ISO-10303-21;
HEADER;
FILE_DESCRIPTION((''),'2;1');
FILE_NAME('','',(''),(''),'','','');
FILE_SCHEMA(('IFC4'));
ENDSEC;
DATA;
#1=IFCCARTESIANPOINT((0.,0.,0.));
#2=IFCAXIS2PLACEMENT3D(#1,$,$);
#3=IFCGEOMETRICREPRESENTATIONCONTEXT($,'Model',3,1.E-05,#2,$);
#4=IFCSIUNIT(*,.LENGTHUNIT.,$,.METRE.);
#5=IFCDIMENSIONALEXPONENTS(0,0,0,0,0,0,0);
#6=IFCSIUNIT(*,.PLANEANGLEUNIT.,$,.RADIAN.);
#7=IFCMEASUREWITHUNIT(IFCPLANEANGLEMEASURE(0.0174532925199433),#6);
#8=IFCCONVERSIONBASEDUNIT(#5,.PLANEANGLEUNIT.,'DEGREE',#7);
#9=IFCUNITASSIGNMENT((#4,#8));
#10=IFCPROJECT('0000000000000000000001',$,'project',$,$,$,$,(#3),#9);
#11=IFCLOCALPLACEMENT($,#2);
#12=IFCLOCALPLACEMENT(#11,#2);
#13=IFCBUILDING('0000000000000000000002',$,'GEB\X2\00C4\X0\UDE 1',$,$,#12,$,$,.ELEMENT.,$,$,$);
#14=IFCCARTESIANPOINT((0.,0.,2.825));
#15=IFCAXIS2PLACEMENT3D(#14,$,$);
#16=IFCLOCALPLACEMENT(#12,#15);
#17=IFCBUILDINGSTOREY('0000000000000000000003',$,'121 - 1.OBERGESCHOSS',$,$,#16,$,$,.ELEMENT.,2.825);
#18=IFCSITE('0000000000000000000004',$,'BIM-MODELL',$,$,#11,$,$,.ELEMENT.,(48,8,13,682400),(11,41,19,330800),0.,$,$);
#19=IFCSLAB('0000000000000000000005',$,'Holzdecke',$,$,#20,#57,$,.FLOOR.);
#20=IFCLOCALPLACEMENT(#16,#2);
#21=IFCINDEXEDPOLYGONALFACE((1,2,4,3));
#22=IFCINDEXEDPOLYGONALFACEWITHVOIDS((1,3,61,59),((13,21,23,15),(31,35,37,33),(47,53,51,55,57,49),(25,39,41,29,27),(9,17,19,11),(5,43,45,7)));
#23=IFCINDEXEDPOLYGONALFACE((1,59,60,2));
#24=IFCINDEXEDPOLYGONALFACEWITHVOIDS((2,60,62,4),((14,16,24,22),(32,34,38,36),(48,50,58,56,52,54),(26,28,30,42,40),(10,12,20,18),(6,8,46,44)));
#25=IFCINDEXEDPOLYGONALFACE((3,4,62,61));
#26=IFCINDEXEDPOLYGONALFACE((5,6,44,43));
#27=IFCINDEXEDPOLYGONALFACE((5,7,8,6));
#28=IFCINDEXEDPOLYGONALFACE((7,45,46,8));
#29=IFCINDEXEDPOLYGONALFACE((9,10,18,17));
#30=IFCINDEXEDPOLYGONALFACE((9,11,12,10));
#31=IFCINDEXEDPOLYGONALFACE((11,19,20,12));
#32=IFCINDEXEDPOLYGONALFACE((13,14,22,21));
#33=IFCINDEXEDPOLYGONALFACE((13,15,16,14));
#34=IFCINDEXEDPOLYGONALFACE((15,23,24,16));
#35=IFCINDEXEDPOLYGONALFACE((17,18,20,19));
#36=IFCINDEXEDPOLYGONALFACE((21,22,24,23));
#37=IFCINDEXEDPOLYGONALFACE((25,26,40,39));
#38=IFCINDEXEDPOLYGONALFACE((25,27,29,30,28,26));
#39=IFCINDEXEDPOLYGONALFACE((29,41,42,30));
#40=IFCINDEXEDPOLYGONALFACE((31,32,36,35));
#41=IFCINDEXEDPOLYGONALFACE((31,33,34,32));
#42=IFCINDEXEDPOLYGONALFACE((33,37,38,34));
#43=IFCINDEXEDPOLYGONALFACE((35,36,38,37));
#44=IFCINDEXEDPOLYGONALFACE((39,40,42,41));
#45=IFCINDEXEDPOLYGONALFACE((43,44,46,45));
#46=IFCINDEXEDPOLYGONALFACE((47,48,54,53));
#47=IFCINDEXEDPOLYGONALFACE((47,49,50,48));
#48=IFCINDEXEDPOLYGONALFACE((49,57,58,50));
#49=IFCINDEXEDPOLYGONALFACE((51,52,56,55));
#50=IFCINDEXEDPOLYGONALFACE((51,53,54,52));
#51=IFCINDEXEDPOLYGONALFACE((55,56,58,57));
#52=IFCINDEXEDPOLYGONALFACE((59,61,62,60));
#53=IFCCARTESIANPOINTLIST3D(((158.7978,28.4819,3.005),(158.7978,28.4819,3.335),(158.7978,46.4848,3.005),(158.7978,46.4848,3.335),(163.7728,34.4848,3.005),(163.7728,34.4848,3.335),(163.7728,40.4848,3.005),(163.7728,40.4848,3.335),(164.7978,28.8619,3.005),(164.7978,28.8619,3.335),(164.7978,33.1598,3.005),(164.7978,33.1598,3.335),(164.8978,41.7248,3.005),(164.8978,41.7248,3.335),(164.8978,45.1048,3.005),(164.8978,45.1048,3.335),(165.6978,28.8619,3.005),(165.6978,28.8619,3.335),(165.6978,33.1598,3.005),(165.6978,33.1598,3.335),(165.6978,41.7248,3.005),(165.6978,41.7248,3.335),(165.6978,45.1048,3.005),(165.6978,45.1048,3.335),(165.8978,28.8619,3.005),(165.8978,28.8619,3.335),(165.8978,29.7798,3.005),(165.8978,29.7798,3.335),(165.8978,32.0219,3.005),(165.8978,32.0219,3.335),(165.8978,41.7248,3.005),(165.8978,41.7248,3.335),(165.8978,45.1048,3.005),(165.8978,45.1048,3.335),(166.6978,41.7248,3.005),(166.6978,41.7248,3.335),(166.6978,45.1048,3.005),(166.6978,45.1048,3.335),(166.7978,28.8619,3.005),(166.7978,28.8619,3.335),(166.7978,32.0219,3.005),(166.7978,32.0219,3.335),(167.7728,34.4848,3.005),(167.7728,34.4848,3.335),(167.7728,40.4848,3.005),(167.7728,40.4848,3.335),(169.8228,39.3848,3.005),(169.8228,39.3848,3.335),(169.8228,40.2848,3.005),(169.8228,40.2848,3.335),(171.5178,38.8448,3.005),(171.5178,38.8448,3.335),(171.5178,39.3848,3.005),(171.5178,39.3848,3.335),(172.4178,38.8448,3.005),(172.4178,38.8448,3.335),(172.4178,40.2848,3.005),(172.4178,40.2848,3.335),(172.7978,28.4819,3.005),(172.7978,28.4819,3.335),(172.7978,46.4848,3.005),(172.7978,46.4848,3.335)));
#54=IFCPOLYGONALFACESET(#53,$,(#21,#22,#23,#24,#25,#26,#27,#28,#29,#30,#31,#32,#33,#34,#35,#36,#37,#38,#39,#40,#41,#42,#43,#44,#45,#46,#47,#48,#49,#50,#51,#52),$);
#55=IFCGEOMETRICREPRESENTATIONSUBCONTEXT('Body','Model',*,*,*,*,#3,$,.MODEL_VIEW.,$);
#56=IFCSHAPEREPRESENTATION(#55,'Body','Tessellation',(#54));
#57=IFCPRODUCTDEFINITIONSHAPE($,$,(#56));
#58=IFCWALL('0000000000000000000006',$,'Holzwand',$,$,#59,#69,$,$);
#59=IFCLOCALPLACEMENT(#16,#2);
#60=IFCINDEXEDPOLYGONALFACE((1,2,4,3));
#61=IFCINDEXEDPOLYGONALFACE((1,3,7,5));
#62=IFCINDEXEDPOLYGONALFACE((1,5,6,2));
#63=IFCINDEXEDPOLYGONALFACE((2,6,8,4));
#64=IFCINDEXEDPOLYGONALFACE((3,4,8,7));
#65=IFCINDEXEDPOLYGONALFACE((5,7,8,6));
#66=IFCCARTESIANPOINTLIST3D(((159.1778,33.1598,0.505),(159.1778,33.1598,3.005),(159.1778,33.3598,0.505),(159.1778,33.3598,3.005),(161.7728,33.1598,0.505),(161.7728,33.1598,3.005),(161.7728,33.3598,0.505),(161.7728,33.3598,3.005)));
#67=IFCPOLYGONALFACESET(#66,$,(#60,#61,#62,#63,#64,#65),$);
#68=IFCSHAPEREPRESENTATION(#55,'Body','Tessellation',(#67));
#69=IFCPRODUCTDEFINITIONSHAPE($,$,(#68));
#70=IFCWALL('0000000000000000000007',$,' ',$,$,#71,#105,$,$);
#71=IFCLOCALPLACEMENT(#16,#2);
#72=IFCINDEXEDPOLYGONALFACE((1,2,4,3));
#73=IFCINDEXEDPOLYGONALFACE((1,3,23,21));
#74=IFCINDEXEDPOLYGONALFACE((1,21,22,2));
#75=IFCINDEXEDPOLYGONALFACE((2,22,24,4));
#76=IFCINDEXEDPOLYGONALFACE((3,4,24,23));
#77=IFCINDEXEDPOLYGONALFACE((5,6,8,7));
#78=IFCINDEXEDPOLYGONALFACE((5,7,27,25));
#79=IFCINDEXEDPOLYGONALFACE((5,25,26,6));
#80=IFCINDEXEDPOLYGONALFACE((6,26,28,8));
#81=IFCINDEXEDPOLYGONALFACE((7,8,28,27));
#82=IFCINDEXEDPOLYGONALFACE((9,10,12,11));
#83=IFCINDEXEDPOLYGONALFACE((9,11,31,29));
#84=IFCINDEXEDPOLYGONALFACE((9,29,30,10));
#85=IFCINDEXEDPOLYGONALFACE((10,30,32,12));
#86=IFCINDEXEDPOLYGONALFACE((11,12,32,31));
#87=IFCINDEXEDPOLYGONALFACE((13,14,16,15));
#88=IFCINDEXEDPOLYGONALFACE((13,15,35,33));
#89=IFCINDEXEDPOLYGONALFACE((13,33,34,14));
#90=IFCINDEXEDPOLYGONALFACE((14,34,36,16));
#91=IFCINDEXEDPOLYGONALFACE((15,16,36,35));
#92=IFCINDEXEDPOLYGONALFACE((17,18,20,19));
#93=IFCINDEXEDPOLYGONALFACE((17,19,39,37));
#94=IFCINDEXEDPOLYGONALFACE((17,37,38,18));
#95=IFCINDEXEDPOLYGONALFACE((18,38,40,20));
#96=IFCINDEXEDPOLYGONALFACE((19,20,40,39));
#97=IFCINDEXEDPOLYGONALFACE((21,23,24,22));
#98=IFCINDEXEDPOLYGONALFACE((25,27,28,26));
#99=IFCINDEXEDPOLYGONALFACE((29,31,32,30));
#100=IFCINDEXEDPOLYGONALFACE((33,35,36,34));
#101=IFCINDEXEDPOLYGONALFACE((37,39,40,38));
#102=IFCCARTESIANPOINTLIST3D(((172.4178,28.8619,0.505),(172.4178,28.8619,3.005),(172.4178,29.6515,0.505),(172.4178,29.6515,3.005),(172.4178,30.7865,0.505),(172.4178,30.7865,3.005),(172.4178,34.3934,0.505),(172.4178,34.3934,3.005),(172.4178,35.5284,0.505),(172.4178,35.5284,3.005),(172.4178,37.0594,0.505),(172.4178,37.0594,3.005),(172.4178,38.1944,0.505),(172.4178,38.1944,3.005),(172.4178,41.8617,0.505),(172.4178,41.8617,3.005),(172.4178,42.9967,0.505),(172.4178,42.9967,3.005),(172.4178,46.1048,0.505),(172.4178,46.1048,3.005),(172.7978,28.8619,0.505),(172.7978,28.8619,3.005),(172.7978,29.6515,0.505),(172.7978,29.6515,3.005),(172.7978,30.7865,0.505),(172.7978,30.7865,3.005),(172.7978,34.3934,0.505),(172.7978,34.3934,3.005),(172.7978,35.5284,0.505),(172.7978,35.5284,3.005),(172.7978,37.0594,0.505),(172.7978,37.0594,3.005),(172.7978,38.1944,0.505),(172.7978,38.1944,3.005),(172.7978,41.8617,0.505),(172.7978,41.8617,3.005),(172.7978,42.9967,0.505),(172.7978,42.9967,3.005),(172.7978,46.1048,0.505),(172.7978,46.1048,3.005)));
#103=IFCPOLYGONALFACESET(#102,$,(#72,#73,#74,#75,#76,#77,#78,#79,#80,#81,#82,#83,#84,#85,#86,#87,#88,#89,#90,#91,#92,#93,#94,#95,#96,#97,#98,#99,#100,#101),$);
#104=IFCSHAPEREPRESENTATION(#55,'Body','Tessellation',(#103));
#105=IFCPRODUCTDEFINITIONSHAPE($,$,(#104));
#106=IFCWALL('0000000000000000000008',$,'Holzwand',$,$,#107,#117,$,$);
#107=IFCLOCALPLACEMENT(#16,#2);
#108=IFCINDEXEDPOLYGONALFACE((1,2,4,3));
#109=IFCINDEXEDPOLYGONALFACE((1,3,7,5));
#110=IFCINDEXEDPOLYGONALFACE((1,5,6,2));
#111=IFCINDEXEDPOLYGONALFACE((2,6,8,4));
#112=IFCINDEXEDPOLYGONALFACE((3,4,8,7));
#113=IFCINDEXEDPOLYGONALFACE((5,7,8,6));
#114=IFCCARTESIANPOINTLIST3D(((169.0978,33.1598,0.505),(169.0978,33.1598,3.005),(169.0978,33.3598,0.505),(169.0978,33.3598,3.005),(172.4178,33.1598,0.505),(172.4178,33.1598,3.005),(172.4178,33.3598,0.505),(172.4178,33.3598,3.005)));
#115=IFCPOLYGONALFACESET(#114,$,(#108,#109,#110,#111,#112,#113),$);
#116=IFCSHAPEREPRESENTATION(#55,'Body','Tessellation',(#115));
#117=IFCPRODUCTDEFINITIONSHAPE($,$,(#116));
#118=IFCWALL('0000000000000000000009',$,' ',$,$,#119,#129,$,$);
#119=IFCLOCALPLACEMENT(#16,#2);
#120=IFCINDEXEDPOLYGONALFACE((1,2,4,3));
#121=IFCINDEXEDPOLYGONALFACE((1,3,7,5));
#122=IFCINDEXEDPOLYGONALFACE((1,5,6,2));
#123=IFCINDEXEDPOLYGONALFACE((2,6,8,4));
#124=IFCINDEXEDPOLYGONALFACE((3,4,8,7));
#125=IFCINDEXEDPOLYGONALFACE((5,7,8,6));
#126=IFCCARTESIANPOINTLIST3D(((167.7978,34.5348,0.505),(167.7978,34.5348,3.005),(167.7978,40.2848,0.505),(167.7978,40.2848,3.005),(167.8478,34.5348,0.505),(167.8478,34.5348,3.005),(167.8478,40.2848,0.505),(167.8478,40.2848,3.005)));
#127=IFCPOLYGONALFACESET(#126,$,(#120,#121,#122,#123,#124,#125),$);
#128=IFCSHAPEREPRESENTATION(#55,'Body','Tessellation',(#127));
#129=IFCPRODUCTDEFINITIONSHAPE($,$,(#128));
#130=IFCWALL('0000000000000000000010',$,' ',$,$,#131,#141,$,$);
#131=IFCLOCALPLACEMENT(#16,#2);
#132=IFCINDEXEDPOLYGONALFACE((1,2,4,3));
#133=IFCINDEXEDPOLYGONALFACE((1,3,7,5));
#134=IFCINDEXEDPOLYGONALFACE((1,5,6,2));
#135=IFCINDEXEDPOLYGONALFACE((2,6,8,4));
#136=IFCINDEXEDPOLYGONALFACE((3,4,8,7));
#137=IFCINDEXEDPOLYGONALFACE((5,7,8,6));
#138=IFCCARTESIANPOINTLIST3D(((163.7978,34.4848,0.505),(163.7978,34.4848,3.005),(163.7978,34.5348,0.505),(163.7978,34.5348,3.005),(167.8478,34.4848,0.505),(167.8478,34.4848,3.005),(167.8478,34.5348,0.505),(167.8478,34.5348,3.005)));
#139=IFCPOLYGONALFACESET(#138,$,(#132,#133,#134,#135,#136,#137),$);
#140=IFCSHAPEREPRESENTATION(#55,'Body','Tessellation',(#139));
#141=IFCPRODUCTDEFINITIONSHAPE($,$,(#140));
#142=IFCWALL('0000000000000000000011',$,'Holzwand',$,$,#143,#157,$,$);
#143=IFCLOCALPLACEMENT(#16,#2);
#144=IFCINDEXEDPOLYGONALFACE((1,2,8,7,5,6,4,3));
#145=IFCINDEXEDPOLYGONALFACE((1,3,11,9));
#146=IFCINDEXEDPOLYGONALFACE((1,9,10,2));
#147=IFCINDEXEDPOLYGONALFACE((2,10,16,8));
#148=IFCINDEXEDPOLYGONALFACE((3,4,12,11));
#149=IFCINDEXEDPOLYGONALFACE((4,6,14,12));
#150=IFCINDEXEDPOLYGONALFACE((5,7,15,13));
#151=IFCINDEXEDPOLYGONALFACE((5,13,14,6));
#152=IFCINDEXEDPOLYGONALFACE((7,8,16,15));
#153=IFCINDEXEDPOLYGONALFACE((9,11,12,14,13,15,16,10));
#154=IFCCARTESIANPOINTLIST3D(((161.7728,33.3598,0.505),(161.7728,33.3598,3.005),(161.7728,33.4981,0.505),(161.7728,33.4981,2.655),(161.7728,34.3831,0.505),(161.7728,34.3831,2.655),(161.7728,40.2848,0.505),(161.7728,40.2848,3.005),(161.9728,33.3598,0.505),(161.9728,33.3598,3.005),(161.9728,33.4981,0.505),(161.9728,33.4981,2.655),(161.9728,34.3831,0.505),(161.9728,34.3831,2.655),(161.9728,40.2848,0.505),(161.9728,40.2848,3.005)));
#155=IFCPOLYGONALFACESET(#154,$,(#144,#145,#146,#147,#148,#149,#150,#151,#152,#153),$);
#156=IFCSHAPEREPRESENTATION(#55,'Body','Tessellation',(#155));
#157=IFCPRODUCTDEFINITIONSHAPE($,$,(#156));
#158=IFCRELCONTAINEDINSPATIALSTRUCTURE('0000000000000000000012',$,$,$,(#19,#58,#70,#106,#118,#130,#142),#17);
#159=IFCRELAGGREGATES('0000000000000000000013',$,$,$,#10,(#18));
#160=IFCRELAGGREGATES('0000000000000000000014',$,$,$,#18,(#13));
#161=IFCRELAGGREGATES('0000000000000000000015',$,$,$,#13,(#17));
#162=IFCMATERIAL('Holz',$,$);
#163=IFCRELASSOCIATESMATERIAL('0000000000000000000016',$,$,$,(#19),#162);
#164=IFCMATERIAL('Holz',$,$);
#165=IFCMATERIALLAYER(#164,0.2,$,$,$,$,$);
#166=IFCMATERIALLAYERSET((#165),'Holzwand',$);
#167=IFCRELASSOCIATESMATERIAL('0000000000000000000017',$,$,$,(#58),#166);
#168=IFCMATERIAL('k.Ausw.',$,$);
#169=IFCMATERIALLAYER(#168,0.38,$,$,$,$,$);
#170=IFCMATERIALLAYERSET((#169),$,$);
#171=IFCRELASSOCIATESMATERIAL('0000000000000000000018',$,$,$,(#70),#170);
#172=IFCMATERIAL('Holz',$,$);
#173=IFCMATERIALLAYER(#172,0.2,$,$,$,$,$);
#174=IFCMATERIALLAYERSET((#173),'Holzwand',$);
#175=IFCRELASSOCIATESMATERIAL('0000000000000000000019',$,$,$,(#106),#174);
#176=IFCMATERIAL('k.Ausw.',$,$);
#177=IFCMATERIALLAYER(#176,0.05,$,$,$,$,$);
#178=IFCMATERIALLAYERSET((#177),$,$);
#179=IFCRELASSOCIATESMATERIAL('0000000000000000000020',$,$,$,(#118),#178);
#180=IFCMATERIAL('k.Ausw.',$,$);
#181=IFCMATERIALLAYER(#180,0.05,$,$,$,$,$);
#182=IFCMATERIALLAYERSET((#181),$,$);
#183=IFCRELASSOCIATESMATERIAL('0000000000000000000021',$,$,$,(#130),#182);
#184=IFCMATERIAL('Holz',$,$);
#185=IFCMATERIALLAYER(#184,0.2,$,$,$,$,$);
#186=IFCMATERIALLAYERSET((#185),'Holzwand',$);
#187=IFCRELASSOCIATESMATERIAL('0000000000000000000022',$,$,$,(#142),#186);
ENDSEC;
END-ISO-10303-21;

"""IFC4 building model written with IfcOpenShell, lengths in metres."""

from ifc_helpers import new_model, entity, si_unit, converted_unit, frame, frame_2d, origin, origin_with_axes, place, context, subcontext, project, spatial, polyline, rectangle, outline, extrude, material, layer, layer_set, layer_usage, element, save


model = new_model("IFC4")

# Units and contexts
model_context = context("Model", 3, precision=1e-05, world=origin())
body_context = subcontext(model_context, "Body", "Model", "MODEL_VIEW")
ifc_project = project(units=[si_unit("LENGTHUNIT", "METRE"), converted_unit("PLANEANGLEUNIT", "DEGREE", entity("IfcPlaneAngleMeasure", 0.0174532925199433), si_unit("PLANEANGLEUNIT", "RADIAN"), dimensions=[0, 0, 0, 0, 0, 0, 0])], contexts=[model_context])

# Site, building, storey
site_placement = place(None, origin())
site = spatial("IfcSite", under=ifc_project, at=site_placement, Name="BIM-MODELL", CompositionType="ELEMENT", RefLatitude=(48, 8, 13, 682400), RefLongitude=(11, 41, 19, 330800), RefElevation=0.0)
building_placement = place(site_placement, origin())
building = spatial("IfcBuilding", under=site, at=building_placement, Name="GEBÄUDE 1", CompositionType="ELEMENT")
storey_placement = place(building_placement, frame((0.0, 0.0, 2.825)))
storey = spatial("IfcBuildingStorey", under=building, at=storey_placement, Name="121 - 1.OBERGESCHOSS", CompositionType="ELEMENT", Elevation=2.825)

# Slab
ifc_material_1 = material(Name="Holz")
slab_placement = place(storey_placement, frame((158.7978, 28.4819, 3.005)))
element("IfcSlab", 1, at=slab_placement, inside=storey, material=ifc_material_1, Name="Holzdecke", PredefinedType="FLOOR", context=body_context, shape_type="SweptSolid", body=[
    extrude(outline(polyline([(0.0, 0.0), (14.0, 0.0), (14.0, 18.0029), (0.0, 18.0029), (0.0, 0.0)]), holes=[polyline([(4.975, 12.0029), (8.975, 12.0029), (8.975, 6.0029), (4.975, 6.0029), (4.975, 12.0029)]), polyline([(6.0, 4.6779), (6.9, 4.6779), (6.9, 0.38), (6.0, 0.38), (6.0, 4.6779)]), polyline([(7.1, 1.2979), (7.1, 3.54), (8.0, 3.54), (8.0, 0.38), (7.1, 0.38), (7.1, 1.2979)]), polyline([(13.62, 10.3629), (12.72, 10.3629), (12.72, 10.9029), (11.025, 10.9029), (11.025, 11.8029), (13.62, 11.8029), (13.62, 10.3629)]), polyline([(7.1, 13.2429), (7.1, 16.6229), (7.9, 16.6229), (7.9, 13.2429), (7.1, 13.2429)]), polyline([(6.9, 13.2429), (6.1, 13.2429), (6.1, 16.6229), (6.9, 16.6229), (6.9, 13.2429)])]), origin_with_axes(), (0.0, 0.0, 1.0), 0.33),
])

# Wall
ifc_material_2 = material(Name="Holz")
ifc_layer_1 = layer(ifc_material_2, 0.2)
ifc_layer_set_1 = layer_set([ifc_layer_1], Name="Holzwand")
ifc_layer_usage_1 = layer_usage(ifc_layer_set_1, "AXIS2", "POSITIVE", 0.0)
wall_1_placement = place(storey_placement, frame((159.1778, 33.1598, 0.505)))
element("IfcWall", 2, at=wall_1_placement, inside=storey, material=ifc_layer_usage_1, Name="Holzwand", context=body_context, shape_type="SweptSolid", body=[
    extrude(rectangle(XDim=2.595, YDim=0.2, at=frame_2d((1.2975, 0.1), x_axis=(1.0, 0.0))), origin_with_axes(), (0.0, 0.0, 1.0), 2.5),
])

# Wall, openings
ifc_material_3 = material(Name="k.Ausw.")
ifc_layer_2 = layer(ifc_material_3, 0.38)
ifc_layer_set_2 = layer_set([ifc_layer_2])
ifc_layer_usage_2 = layer_usage(ifc_layer_set_2, "AXIS2", "POSITIVE", 0.0)
wall_2_placement = place(storey_placement, frame((172.7978, 28.8619, 0.505), z_axis=(0.0, 0.0, 1.0), x_axis=(0.0, 1.0, 0.0)))
wall_2 = element("IfcWall", 3, at=wall_2_placement, inside=storey, material=ifc_layer_usage_2, Name=" ", context=body_context, shape_type="SweptSolid", body=[
    extrude(rectangle(XDim=17.2429, YDim=0.38, at=frame_2d((8.6214, 0.19), x_axis=(1.0, 0.0))), origin_with_axes(), (0.0, 0.0, 1.0), 2.5),
])
opening_1_placement = place(wall_2_placement, frame((14.1348, 0.38, 0.0), z_axis=(0.0, -1.0, 0.0), x_axis=(0.0, 0.0, 1.0)))
element("IfcOpeningElement", 4, at=opening_1_placement, cuts=wall_2, ObjectType="Opening", context=body_context, shape_type="SweptSolid", body=[
    extrude(outline(polyline([(0.0, 1.135), (2.5, 1.135), (2.5, 0.0), (0.0, 0.0), (0.0, 1.135)])), origin_with_axes(), (0.0, 0.0, 1.0), 0.38),
])
opening_2_placement = place(wall_2_placement, frame((9.3325, 0.38, 0.0), z_axis=(0.0, -1.0, 0.0), x_axis=(0.0, 0.0, 1.0)))
element("IfcOpeningElement", 5, at=opening_2_placement, cuts=wall_2, ObjectType="Opening", context=body_context, shape_type="SweptSolid", body=[
    extrude(outline(polyline([(0.0, 1.135), (2.5, 1.135), (2.5, 0.0), (0.0, 0.0), (0.0, 1.135)])), origin_with_axes(), (0.0, 0.0, 1.0), 0.38),
])
opening_3_placement = place(wall_2_placement, frame((6.6664, 0.38, 0.0), z_axis=(0.0, -1.0, 0.0), x_axis=(0.0, 0.0, 1.0)))
element("IfcOpeningElement", 6, at=opening_3_placement, cuts=wall_2, ObjectType="Opening", context=body_context, shape_type="SweptSolid", body=[
    extrude(outline(polyline([(0.0, 1.135), (2.5, 1.135), (2.5, 0.0), (0.0, 0.0), (0.0, 1.135)])), origin_with_axes(), (0.0, 0.0, 1.0), 0.38),
])
opening_4_placement = place(wall_2_placement, frame((1.9246, 0.38, 0.0), z_axis=(0.0, -1.0, 0.0), x_axis=(0.0, 0.0, 1.0)))
element("IfcOpeningElement", 7, at=opening_4_placement, cuts=wall_2, ObjectType="Opening", context=body_context, shape_type="SweptSolid", body=[
    extrude(outline(polyline([(0.0, 1.135), (2.5, 1.135), (2.5, 0.0), (0.0, 0.0), (0.0, 1.135)])), origin_with_axes(), (0.0, 0.0, 1.0), 0.38),
])

# Walls
ifc_material_4 = material(Name="Holz")
ifc_layer_3 = layer(ifc_material_4, 0.2)
ifc_layer_set_3 = layer_set([ifc_layer_3], Name="Holzwand")
ifc_layer_usage_3 = layer_usage(ifc_layer_set_3, "AXIS2", "POSITIVE", 0.0)
wall_3_placement = place(storey_placement, frame((169.0978, 33.1598, 0.505)))
element("IfcWall", 8, at=wall_3_placement, inside=storey, material=ifc_layer_usage_3, Name="Holzwand", context=body_context, shape_type="SweptSolid", body=[
    extrude(rectangle(XDim=3.32, YDim=0.2, at=frame_2d((1.66, 0.1), x_axis=(1.0, 0.0))), origin_with_axes(), (0.0, 0.0, 1.0), 2.5),
])
ifc_material_5 = material(Name="k.Ausw.")
ifc_layer_4 = layer(ifc_material_5, 0.05)
ifc_layer_set_4 = layer_set([ifc_layer_4])
ifc_layer_usage_4 = layer_usage(ifc_layer_set_4, "AXIS2", "POSITIVE", 0.0)
wall_4_placement = place(storey_placement, frame((167.8478, 34.5348, 0.505), z_axis=(0.0, 0.0, 1.0), x_axis=(0.0, 1.0, 0.0)))
element("IfcWall", 9, at=wall_4_placement, inside=storey, material=ifc_layer_usage_4, Name=" ", context=body_context, shape_type="SweptSolid", body=[
    extrude(rectangle(XDim=5.75, YDim=0.05, at=frame_2d((2.875, 0.025), x_axis=(1.0, 0.0))), origin_with_axes(), (0.0, 0.0, 1.0), 2.5),
])
ifc_material_6 = material(Name="k.Ausw.")
ifc_layer_5 = layer(ifc_material_6, 0.05)
ifc_layer_set_5 = layer_set([ifc_layer_5])
ifc_layer_usage_5 = layer_usage(ifc_layer_set_5, "AXIS2", "POSITIVE", 0.0)
wall_5_placement = place(storey_placement, frame((163.7978, 34.4848, 0.505), z_axis=(0.0, 0.0, 1.0), x_axis=(1.0, 0.0, 0.0)))
element("IfcWall", 10, at=wall_5_placement, inside=storey, material=ifc_layer_usage_5, Name=" ", context=body_context, shape_type="SweptSolid", body=[
    extrude(rectangle(XDim=4.05, YDim=0.05, at=frame_2d((2.025, 0.025), x_axis=(1.0, 0.0))), origin_with_axes(), (0.0, 0.0, 1.0), 2.5),
])

# Wall, opening
ifc_material_7 = material(Name="Holz")
ifc_layer_6 = layer(ifc_material_7, 0.2)
ifc_layer_set_6 = layer_set([ifc_layer_6], Name="Holzwand")
ifc_layer_usage_6 = layer_usage(ifc_layer_set_6, "AXIS2", "POSITIVE", 0.0)
wall_6_placement = place(storey_placement, frame((161.9728, 33.3598, 0.505), z_axis=(0.0, 0.0, 1.0), x_axis=(0.0, 1.0, 0.0)))
wall_6 = element("IfcWall", 11, at=wall_6_placement, inside=storey, material=ifc_layer_usage_6, Name="Holzwand", context=body_context, shape_type="SweptSolid", body=[
    extrude(rectangle(XDim=6.925, YDim=0.2, at=frame_2d((3.4625, 0.1), x_axis=(1.0, 0.0))), origin_with_axes(), (0.0, 0.0, 1.0), 2.5),
])
opening_5_placement = place(wall_6_placement, frame((0.1383, 0.0, -0.15), z_axis=(0.0, 1.0, 0.0), x_axis=(0.0, 0.0, 1.0)))
element("IfcOpeningElement", 12, at=opening_5_placement, cuts=wall_6, ObjectType="Opening", context=body_context, shape_type="SweptSolid", body=[
    extrude(outline(polyline([(0.0, 0.885), (2.3, 0.885), (2.3, 0.0), (0.0, 0.0), (0.0, 0.885)])), origin_with_axes(), (0.0, 0.0, 1.0), 0.2),
])

save(model, "model.ifc")
